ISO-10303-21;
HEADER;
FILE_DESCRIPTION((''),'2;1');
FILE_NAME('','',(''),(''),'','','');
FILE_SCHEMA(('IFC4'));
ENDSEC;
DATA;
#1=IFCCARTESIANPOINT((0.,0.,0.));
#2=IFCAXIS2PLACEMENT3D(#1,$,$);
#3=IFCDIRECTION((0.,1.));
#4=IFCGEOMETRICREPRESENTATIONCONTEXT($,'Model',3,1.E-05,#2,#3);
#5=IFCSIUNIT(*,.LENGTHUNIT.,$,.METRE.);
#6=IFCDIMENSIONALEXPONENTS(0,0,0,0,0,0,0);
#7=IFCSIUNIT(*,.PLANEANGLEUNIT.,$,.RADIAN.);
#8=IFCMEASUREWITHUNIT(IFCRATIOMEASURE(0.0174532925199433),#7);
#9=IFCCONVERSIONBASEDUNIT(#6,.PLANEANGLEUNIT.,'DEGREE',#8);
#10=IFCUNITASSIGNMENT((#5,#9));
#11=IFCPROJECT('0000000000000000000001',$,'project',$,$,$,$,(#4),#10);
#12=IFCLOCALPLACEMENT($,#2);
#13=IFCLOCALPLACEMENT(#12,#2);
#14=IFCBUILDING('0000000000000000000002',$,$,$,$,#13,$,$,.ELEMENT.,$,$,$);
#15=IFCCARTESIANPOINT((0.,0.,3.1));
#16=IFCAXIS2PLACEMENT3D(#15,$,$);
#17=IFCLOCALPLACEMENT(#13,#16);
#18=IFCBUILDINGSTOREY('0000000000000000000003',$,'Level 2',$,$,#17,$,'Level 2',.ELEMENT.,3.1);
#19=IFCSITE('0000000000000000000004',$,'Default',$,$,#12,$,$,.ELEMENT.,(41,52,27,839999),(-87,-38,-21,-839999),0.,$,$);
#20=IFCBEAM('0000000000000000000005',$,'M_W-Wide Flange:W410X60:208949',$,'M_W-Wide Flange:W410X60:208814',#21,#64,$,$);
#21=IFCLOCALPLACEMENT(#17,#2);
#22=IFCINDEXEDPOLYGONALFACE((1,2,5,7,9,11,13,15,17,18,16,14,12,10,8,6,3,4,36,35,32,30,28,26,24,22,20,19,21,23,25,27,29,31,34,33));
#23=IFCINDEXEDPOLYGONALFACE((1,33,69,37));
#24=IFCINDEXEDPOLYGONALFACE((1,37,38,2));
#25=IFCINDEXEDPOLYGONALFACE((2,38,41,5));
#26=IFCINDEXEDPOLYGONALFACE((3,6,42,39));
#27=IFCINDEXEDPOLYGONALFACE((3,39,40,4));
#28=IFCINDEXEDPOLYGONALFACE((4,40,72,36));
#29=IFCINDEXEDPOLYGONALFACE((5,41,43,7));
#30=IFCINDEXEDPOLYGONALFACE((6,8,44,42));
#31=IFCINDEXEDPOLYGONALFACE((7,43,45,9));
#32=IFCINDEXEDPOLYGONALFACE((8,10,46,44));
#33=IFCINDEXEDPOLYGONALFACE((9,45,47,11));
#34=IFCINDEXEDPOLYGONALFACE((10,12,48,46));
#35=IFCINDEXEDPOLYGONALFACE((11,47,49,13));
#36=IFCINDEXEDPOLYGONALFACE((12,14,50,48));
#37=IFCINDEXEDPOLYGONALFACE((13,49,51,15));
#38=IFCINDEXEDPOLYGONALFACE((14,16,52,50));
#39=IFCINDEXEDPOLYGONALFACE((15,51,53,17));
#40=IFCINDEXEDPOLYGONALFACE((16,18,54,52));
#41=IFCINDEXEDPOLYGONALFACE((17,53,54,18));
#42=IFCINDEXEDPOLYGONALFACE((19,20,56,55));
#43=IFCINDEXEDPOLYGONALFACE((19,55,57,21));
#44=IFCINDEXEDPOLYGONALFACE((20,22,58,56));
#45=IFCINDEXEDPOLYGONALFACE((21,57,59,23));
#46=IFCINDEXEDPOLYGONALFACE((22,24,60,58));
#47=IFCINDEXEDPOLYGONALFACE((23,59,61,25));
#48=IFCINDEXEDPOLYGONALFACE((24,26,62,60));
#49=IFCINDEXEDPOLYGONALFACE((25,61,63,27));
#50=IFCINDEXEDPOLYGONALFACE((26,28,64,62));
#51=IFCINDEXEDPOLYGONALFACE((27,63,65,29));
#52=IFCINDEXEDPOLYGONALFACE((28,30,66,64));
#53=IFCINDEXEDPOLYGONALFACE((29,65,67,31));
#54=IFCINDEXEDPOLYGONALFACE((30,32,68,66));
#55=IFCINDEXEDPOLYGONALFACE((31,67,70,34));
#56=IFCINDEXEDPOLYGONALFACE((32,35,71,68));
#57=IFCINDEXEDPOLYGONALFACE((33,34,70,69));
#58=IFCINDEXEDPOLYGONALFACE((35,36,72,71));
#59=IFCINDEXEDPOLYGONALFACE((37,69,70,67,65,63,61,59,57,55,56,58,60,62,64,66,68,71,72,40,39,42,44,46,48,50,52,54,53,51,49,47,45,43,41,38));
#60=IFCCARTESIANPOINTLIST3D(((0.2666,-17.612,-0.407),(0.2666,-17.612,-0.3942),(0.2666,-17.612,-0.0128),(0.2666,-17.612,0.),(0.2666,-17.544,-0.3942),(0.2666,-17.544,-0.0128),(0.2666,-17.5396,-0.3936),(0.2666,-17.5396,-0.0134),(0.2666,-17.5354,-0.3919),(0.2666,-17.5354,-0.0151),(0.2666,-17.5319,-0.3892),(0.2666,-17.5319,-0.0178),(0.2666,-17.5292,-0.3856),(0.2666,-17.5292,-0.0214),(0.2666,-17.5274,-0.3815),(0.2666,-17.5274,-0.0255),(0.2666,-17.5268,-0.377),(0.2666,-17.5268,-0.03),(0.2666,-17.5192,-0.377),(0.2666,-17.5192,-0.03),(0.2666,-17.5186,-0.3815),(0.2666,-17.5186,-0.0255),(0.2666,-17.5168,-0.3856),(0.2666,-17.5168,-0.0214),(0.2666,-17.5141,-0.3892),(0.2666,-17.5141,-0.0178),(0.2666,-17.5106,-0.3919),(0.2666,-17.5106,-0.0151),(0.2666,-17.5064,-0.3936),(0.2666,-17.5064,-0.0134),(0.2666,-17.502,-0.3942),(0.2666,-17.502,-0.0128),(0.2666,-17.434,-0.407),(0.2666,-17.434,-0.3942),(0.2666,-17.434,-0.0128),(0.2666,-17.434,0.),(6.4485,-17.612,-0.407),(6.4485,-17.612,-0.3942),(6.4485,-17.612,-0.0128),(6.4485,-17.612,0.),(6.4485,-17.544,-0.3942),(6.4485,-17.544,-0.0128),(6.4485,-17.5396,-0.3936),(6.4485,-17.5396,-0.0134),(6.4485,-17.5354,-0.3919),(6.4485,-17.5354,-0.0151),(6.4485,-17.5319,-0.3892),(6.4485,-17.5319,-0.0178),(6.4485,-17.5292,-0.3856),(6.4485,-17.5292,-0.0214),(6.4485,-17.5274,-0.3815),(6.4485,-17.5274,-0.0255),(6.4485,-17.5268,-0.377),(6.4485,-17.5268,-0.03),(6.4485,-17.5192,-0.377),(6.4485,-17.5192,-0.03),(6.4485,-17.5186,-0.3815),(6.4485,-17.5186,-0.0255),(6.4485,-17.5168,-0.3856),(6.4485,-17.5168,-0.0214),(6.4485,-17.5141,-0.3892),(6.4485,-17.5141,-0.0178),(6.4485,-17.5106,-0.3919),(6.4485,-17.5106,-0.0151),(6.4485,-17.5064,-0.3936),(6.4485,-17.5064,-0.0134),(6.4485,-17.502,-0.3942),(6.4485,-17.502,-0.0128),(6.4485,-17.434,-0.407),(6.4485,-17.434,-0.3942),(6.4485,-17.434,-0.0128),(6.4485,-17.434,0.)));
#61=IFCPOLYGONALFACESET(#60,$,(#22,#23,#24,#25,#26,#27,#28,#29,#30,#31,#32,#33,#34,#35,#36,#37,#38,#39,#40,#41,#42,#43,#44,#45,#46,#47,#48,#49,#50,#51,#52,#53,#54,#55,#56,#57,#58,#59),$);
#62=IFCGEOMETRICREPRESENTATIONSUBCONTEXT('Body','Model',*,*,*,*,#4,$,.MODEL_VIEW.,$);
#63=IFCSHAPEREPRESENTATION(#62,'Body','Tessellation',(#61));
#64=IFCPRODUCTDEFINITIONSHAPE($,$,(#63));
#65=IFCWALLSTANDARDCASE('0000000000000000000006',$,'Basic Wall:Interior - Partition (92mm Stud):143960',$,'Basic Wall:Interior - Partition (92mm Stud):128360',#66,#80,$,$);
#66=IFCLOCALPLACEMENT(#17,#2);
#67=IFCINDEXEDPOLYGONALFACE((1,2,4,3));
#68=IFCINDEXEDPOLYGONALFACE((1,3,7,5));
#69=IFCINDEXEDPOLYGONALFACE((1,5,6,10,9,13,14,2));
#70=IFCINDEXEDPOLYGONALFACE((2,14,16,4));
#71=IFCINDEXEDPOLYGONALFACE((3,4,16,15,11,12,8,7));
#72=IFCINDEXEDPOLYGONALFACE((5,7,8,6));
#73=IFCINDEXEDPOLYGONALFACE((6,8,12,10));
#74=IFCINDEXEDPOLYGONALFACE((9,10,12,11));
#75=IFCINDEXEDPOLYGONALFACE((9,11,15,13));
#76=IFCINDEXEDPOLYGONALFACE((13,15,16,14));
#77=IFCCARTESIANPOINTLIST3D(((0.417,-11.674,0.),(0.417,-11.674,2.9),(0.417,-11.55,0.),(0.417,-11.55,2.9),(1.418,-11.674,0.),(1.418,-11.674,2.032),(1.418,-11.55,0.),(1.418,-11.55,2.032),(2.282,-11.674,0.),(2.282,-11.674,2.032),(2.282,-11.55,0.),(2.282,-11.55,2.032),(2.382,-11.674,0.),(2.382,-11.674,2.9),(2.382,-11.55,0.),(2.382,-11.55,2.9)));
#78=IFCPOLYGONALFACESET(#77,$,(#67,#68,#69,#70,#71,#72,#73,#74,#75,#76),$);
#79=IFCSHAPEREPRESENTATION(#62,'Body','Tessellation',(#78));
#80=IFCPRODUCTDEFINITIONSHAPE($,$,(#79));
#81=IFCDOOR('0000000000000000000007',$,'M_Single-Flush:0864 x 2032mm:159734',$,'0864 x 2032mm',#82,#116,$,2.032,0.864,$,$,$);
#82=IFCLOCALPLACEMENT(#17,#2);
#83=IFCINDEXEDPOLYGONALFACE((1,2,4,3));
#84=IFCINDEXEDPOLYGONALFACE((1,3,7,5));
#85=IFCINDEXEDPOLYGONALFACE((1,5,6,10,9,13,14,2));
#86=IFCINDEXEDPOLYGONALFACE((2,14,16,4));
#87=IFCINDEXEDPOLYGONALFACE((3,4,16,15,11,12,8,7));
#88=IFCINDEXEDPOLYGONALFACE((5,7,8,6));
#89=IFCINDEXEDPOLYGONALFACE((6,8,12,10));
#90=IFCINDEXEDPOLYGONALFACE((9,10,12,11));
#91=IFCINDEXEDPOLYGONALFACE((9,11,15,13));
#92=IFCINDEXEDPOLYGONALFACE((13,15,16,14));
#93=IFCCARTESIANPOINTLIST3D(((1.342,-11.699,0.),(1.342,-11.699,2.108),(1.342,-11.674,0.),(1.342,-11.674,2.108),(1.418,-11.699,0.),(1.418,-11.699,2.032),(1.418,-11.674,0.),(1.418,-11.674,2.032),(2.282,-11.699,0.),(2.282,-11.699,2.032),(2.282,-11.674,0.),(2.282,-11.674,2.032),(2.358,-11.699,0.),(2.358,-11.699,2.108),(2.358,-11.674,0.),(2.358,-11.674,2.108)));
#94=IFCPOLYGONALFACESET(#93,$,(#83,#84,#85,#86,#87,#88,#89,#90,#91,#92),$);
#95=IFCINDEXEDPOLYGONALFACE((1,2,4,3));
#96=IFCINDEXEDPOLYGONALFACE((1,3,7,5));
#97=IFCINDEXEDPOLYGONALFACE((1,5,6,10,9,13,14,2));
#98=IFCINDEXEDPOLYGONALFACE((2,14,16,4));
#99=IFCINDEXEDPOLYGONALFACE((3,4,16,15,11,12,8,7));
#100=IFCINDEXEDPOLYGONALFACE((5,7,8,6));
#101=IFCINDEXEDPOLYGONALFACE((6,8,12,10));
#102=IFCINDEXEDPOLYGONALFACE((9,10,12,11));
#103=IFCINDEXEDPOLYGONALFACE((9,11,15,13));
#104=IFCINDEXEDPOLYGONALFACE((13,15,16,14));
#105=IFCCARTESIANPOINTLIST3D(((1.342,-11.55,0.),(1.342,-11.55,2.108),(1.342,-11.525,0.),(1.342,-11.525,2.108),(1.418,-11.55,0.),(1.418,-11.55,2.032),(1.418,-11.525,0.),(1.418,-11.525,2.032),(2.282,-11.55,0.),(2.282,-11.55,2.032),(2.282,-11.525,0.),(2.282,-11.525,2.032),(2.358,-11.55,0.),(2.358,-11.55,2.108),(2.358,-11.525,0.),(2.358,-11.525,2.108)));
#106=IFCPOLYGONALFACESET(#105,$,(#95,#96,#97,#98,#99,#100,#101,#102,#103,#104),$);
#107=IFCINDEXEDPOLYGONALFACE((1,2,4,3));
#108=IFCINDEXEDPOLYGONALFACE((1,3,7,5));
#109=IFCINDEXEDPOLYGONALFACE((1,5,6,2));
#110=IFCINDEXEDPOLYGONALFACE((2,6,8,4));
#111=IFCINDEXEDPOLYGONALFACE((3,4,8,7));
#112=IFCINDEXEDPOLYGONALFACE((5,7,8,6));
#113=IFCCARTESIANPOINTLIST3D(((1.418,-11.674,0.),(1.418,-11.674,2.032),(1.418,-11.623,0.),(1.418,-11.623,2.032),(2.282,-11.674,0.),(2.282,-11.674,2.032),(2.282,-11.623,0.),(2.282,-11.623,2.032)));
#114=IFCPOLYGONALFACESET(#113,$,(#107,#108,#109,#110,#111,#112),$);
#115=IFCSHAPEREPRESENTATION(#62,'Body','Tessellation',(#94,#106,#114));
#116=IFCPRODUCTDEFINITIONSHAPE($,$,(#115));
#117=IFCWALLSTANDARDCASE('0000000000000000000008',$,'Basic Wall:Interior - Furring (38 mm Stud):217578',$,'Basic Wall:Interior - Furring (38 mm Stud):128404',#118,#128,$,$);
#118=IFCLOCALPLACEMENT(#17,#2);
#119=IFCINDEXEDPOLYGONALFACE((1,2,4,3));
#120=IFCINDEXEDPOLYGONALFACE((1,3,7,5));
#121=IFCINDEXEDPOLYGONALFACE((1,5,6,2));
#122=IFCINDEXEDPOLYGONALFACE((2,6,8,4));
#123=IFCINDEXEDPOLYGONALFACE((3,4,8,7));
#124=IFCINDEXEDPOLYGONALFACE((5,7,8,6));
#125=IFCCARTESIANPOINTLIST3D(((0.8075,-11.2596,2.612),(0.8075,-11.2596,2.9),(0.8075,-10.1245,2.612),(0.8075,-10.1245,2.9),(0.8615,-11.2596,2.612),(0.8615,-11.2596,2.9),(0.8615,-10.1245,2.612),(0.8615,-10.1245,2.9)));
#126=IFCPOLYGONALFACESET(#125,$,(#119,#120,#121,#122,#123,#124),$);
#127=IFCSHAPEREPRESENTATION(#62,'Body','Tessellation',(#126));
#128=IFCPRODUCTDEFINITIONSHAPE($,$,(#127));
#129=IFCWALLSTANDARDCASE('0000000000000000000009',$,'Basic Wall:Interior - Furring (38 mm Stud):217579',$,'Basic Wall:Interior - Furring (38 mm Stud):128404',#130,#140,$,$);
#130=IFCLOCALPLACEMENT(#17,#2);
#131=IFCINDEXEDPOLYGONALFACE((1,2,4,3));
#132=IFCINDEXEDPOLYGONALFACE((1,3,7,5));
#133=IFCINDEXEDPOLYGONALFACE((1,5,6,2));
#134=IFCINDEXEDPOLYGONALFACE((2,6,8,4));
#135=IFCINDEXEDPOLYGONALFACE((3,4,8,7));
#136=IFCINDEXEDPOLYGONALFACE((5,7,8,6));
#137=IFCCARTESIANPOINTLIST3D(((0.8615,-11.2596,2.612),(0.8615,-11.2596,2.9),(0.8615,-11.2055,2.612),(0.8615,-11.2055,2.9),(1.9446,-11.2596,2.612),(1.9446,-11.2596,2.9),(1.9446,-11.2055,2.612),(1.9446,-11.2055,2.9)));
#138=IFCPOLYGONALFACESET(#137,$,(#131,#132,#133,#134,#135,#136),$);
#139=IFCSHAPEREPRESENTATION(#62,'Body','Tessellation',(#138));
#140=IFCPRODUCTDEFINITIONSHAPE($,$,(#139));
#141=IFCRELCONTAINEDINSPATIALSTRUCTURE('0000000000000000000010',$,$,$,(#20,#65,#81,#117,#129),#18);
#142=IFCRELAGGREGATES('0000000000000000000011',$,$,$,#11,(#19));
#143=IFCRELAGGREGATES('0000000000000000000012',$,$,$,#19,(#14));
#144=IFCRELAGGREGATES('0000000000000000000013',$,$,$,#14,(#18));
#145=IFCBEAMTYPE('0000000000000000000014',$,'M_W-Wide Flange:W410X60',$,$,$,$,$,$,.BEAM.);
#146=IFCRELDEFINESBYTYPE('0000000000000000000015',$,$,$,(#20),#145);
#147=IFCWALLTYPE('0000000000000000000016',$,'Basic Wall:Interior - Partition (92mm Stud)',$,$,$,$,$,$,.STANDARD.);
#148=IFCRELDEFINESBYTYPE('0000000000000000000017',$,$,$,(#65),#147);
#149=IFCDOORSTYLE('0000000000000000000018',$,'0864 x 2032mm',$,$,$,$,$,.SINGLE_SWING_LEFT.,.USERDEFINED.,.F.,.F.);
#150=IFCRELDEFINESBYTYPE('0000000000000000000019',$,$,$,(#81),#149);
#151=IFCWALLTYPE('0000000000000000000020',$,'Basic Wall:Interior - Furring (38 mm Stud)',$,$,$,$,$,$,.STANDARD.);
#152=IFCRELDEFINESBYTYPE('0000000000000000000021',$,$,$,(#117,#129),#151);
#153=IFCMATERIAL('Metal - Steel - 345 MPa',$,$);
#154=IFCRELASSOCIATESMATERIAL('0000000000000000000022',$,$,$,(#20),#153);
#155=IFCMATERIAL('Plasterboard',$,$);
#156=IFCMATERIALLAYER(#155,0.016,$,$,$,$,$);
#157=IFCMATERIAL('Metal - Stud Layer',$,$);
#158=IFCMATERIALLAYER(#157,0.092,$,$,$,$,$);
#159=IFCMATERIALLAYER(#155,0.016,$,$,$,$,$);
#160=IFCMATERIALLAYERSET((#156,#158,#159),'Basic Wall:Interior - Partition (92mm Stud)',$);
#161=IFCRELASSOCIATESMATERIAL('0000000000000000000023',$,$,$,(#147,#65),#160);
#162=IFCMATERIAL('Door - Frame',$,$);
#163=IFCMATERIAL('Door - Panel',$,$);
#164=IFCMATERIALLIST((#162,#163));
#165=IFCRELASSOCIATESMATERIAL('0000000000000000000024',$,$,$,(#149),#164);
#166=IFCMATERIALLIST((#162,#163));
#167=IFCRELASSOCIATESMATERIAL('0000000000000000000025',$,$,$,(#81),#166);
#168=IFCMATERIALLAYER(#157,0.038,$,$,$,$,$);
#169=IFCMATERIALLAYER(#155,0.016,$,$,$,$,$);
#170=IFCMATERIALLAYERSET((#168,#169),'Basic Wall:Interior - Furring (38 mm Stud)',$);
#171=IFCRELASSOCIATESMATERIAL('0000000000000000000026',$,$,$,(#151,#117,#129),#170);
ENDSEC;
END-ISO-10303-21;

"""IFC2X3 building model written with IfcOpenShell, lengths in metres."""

from ifc_helpers import new_model, entity, si_unit, converted_unit, direction, frame, frame_2d, origin, place, context, subcontext, project, spatial, polyline, rectangle, i_section, outline, extrude, source, transform, mapped, material, material_list, layer, layer_set, layer_usage, type_object, type_shapes, element, fill, save


model = new_model("IFC2X3")

# Units and contexts
model_context = context("Model", 3, precision=1e-05, world=origin(), true_north=direction((0.0, 1.0)))
body_context = subcontext(model_context, "Body", "Model", "MODEL_VIEW")
ifc_project = project(units=[si_unit("LENGTHUNIT", "METRE"), converted_unit("PLANEANGLEUNIT", "DEGREE", entity("IfcRatioMeasure", 0.0174532925199433), si_unit("PLANEANGLEUNIT", "RADIAN"), dimensions=[0, 0, 0, 0, 0, 0, 0])], contexts=[model_context])

# Site, building, storey
site_placement = place(None, origin())
site = spatial("IfcSite", under=ifc_project, at=site_placement, Name="Default", CompositionType="ELEMENT", RefLatitude=(41, 52, 27, 839999), RefLongitude=(-87, -38, -21, -839999), RefElevation=0.0)
building_placement = place(site_placement, origin())
building = spatial("IfcBuilding", under=site, at=building_placement, CompositionType="ELEMENT")
storey_placement = place(building_placement, frame((0.0, 0.0, 3.1)))
storey = spatial("IfcBuildingStorey", under=building, at=storey_placement, Name="Level 2", LongName="Level 2", CompositionType="ELEMENT", Elevation=3.1)

# Beam
ifc_material_1 = material(Name="Metal - Steel - 345 MPa")
beam_type = type_object("IfcBeamType", Name="M_W-Wide Flange:W410X60", PredefinedType="BEAM")
beam_placement = place(storey_placement, frame((0.2666, -17.523, 0.0)))
element("IfcBeam", 1, at=beam_placement, inside=storey, type_object=beam_type, material=ifc_material_1, Name="M_W-Wide Flange:W410X60:208949", ObjectType="M_W-Wide Flange:W410X60:208814", context=body_context, shape_type="SweptSolid", body=[
    extrude(i_section(OverallWidth=0.178, OverallDepth=0.407, WebThickness=0.0077, FlangeThickness=0.0128, FilletRadius=0.0172, at=frame_2d((0.0, 0.0), x_axis=(0.0, 1.0))), frame((0.0, 0.0, -0.2035), z_axis=(1.0, 0.0, 0.0), x_axis=(0.0, 0.0, -1.0)), (0.0, 0.0, 1.0), 6.1819),
])

# Shared definitions
ifc_material_2 = material(Name="Metal - Stud Layer")
ifc_material_3 = material(Name="Plasterboard")

# Wall, opening, door
ifc_layer_1 = layer(ifc_material_3, 0.016)
ifc_layer_2 = layer(ifc_material_2, 0.092)
ifc_layer_3 = layer(ifc_material_3, 0.016)
ifc_layer_set_1 = layer_set([ifc_layer_1, ifc_layer_2, ifc_layer_3], Name="Basic Wall:Interior - Partition (92mm Stud)")
ifc_layer_usage_1 = layer_usage(ifc_layer_set_1, "AXIS2", "NEGATIVE", 0.062)
wall_type_1 = type_object("IfcWallType", Name="Basic Wall:Interior - Partition (92mm Stud)", PredefinedType="STANDARD", material=ifc_layer_set_1)
wall_1_placement = place(storey_placement, frame((2.382, -11.612, 0.0), z_axis=(0.0, 0.0, 1.0), x_axis=(-1.0, 0.0, 0.0)))
wall_1 = element("IfcWallStandardCase", 2, at=wall_1_placement, inside=storey, type_object=wall_type_1, material=ifc_layer_usage_1, Name="Basic Wall:Interior - Partition (92mm Stud):143960", ObjectType="Basic Wall:Interior - Partition (92mm Stud):128360", context=body_context, shape_type="SweptSolid", body=[
    extrude(rectangle(XDim=1.965, YDim=0.124, at=frame_2d((0.9825, 0.0), x_axis=(-1.0, 0.0))), origin(), (0.0, 0.0, 1.0), 2.9),
])
opening_1_placement = place(wall_1_placement, frame((0.1, -0.062, 0.0)))
opening_1 = element("IfcOpeningElement", 3, at=opening_1_placement, cuts=wall_1, ObjectType="Opening", context=body_context, shape_type="SweptSolid", body=[
    extrude(rectangle(XDim=0.864, YDim=2.032, at=frame_2d((1.016, 0.432), x_axis=(0.0, -1.0))), frame((0.0, 0.0, 0.0), z_axis=(0.0, 1.0, 0.0), x_axis=(0.0, 0.0, 1.0)), (0.0, 0.0, 1.0), 0.124),
])
ifc_material_4 = material(Name="Door - Frame")
ifc_material_5 = material(Name="Door - Panel")
ifc_material_list_1 = material_list([ifc_material_4, ifc_material_5])
ifc_material_list_2 = material_list([ifc_material_4, ifc_material_5])
door_style = type_object("IfcDoorStyle", Name="0864 x 2032mm", ConstructionType="USERDEFINED", OperationType="SINGLE_SWING_LEFT", ParameterTakesPrecedence=False, Sizeable=False, material=ifc_material_list_2)
shared_shape_1 = source(origin(), body_context, "Body", "SweptSolid", [
    extrude(outline(polyline([(-0.508, -1.073), (0.508, -1.073), (0.508, 1.035), (0.432, 1.035), (0.432, -0.997), (-0.432, -0.997), (-0.432, 1.035), (-0.508, 1.035), (-0.508, -1.073)])), frame((0.432, 0.149, 1.035), z_axis=(0.0, -1.0, 0.0), x_axis=(-1.0, 0.0, 0.0)), (0.0, 0.0, 1.0), 0.025),
    extrude(outline(polyline([(-1.073, -0.508), (1.035, -0.508), (1.035, -0.432), (-0.997, -0.432), (-0.997, 0.432), (1.035, 0.432), (1.035, 0.508), (-1.073, 0.508), (-1.073, -0.508)])), frame((0.432, 0.0, 1.035), z_axis=(0.0, -1.0, 0.0), x_axis=(0.0, 0.0, -1.0)), (0.0, 0.0, 1.0), 0.025),
    extrude(rectangle(XDim=0.864, YDim=0.051, at=frame_2d((0.0, 0.0), x_axis=(1.0, 0.0))), frame((0.432, 0.0985, 0.0)), (0.0, 0.0, 1.0), 2.032),
])
type_shapes(door_style, [shared_shape_1])
door_placement = place(opening_1_placement, origin())
door = element("IfcDoor", 4, at=door_placement, inside=storey, type_object=door_style, material=ifc_material_list_1, Name="M_Single-Flush:0864 x 2032mm:159734", ObjectType="0864 x 2032mm", OverallHeight=2.032, OverallWidth=0.864, context=body_context, shape_type="MappedRepresentation", body=[
    mapped(shared_shape_1, transform((0.0, 0.0, 0.0), scale=1.0)),
])
fill(opening_1, door)

# Walls
ifc_layer_4 = layer(ifc_material_2, 0.038)
ifc_layer_5 = layer(ifc_material_3, 0.016)
ifc_layer_set_2 = layer_set([ifc_layer_4, ifc_layer_5], Name="Basic Wall:Interior - Furring (38 mm Stud)")
ifc_layer_usage_2 = layer_usage(ifc_layer_set_2, "AXIS2", "NEGATIVE", 0.027)
wall_type_2 = type_object("IfcWallType", Name="Basic Wall:Interior - Furring (38 mm Stud)", PredefinedType="STANDARD", material=ifc_layer_set_2)
wall_2_placement = place(storey_placement, frame((0.8345, -11.2596, 2.612), z_axis=(0.0, 0.0, 1.0), x_axis=(0.0, 1.0, 0.0)))
element("IfcWallStandardCase", 5, at=wall_2_placement, inside=storey, type_object=wall_type_2, material=ifc_layer_usage_2, Name="Basic Wall:Interior - Furring (38 mm Stud):217578", ObjectType="Basic Wall:Interior - Furring (38 mm Stud):128404", context=body_context, shape_type="SweptSolid", body=[
    extrude(rectangle(XDim=1.1351, YDim=0.054, at=frame_2d((0.5675, 0.0), x_axis=(-1.0, 0.0))), origin(), (0.0, 0.0, 1.0), 0.288),
])
ifc_layer_usage_3 = layer_usage(ifc_layer_set_2, "AXIS2", "NEGATIVE", 0.027)
wall_3_placement = place(storey_placement, frame((1.9446, -11.2325, 2.612), z_axis=(0.0, 0.0, 1.0), x_axis=(-1.0, 0.0, 0.0)))
element("IfcWallStandardCase", 6, at=wall_3_placement, inside=storey, type_object=wall_type_2, material=ifc_layer_usage_3, Name="Basic Wall:Interior - Furring (38 mm Stud):217579", ObjectType="Basic Wall:Interior - Furring (38 mm Stud):128404", context=body_context, shape_type="SweptSolid", body=[
    extrude(rectangle(XDim=1.0831, YDim=0.054, at=frame_2d((0.5415, 0.0), x_axis=(-1.0, 0.0))), origin(), (0.0, 0.0, 1.0), 0.288),
])

save(model, "model.ifc")
